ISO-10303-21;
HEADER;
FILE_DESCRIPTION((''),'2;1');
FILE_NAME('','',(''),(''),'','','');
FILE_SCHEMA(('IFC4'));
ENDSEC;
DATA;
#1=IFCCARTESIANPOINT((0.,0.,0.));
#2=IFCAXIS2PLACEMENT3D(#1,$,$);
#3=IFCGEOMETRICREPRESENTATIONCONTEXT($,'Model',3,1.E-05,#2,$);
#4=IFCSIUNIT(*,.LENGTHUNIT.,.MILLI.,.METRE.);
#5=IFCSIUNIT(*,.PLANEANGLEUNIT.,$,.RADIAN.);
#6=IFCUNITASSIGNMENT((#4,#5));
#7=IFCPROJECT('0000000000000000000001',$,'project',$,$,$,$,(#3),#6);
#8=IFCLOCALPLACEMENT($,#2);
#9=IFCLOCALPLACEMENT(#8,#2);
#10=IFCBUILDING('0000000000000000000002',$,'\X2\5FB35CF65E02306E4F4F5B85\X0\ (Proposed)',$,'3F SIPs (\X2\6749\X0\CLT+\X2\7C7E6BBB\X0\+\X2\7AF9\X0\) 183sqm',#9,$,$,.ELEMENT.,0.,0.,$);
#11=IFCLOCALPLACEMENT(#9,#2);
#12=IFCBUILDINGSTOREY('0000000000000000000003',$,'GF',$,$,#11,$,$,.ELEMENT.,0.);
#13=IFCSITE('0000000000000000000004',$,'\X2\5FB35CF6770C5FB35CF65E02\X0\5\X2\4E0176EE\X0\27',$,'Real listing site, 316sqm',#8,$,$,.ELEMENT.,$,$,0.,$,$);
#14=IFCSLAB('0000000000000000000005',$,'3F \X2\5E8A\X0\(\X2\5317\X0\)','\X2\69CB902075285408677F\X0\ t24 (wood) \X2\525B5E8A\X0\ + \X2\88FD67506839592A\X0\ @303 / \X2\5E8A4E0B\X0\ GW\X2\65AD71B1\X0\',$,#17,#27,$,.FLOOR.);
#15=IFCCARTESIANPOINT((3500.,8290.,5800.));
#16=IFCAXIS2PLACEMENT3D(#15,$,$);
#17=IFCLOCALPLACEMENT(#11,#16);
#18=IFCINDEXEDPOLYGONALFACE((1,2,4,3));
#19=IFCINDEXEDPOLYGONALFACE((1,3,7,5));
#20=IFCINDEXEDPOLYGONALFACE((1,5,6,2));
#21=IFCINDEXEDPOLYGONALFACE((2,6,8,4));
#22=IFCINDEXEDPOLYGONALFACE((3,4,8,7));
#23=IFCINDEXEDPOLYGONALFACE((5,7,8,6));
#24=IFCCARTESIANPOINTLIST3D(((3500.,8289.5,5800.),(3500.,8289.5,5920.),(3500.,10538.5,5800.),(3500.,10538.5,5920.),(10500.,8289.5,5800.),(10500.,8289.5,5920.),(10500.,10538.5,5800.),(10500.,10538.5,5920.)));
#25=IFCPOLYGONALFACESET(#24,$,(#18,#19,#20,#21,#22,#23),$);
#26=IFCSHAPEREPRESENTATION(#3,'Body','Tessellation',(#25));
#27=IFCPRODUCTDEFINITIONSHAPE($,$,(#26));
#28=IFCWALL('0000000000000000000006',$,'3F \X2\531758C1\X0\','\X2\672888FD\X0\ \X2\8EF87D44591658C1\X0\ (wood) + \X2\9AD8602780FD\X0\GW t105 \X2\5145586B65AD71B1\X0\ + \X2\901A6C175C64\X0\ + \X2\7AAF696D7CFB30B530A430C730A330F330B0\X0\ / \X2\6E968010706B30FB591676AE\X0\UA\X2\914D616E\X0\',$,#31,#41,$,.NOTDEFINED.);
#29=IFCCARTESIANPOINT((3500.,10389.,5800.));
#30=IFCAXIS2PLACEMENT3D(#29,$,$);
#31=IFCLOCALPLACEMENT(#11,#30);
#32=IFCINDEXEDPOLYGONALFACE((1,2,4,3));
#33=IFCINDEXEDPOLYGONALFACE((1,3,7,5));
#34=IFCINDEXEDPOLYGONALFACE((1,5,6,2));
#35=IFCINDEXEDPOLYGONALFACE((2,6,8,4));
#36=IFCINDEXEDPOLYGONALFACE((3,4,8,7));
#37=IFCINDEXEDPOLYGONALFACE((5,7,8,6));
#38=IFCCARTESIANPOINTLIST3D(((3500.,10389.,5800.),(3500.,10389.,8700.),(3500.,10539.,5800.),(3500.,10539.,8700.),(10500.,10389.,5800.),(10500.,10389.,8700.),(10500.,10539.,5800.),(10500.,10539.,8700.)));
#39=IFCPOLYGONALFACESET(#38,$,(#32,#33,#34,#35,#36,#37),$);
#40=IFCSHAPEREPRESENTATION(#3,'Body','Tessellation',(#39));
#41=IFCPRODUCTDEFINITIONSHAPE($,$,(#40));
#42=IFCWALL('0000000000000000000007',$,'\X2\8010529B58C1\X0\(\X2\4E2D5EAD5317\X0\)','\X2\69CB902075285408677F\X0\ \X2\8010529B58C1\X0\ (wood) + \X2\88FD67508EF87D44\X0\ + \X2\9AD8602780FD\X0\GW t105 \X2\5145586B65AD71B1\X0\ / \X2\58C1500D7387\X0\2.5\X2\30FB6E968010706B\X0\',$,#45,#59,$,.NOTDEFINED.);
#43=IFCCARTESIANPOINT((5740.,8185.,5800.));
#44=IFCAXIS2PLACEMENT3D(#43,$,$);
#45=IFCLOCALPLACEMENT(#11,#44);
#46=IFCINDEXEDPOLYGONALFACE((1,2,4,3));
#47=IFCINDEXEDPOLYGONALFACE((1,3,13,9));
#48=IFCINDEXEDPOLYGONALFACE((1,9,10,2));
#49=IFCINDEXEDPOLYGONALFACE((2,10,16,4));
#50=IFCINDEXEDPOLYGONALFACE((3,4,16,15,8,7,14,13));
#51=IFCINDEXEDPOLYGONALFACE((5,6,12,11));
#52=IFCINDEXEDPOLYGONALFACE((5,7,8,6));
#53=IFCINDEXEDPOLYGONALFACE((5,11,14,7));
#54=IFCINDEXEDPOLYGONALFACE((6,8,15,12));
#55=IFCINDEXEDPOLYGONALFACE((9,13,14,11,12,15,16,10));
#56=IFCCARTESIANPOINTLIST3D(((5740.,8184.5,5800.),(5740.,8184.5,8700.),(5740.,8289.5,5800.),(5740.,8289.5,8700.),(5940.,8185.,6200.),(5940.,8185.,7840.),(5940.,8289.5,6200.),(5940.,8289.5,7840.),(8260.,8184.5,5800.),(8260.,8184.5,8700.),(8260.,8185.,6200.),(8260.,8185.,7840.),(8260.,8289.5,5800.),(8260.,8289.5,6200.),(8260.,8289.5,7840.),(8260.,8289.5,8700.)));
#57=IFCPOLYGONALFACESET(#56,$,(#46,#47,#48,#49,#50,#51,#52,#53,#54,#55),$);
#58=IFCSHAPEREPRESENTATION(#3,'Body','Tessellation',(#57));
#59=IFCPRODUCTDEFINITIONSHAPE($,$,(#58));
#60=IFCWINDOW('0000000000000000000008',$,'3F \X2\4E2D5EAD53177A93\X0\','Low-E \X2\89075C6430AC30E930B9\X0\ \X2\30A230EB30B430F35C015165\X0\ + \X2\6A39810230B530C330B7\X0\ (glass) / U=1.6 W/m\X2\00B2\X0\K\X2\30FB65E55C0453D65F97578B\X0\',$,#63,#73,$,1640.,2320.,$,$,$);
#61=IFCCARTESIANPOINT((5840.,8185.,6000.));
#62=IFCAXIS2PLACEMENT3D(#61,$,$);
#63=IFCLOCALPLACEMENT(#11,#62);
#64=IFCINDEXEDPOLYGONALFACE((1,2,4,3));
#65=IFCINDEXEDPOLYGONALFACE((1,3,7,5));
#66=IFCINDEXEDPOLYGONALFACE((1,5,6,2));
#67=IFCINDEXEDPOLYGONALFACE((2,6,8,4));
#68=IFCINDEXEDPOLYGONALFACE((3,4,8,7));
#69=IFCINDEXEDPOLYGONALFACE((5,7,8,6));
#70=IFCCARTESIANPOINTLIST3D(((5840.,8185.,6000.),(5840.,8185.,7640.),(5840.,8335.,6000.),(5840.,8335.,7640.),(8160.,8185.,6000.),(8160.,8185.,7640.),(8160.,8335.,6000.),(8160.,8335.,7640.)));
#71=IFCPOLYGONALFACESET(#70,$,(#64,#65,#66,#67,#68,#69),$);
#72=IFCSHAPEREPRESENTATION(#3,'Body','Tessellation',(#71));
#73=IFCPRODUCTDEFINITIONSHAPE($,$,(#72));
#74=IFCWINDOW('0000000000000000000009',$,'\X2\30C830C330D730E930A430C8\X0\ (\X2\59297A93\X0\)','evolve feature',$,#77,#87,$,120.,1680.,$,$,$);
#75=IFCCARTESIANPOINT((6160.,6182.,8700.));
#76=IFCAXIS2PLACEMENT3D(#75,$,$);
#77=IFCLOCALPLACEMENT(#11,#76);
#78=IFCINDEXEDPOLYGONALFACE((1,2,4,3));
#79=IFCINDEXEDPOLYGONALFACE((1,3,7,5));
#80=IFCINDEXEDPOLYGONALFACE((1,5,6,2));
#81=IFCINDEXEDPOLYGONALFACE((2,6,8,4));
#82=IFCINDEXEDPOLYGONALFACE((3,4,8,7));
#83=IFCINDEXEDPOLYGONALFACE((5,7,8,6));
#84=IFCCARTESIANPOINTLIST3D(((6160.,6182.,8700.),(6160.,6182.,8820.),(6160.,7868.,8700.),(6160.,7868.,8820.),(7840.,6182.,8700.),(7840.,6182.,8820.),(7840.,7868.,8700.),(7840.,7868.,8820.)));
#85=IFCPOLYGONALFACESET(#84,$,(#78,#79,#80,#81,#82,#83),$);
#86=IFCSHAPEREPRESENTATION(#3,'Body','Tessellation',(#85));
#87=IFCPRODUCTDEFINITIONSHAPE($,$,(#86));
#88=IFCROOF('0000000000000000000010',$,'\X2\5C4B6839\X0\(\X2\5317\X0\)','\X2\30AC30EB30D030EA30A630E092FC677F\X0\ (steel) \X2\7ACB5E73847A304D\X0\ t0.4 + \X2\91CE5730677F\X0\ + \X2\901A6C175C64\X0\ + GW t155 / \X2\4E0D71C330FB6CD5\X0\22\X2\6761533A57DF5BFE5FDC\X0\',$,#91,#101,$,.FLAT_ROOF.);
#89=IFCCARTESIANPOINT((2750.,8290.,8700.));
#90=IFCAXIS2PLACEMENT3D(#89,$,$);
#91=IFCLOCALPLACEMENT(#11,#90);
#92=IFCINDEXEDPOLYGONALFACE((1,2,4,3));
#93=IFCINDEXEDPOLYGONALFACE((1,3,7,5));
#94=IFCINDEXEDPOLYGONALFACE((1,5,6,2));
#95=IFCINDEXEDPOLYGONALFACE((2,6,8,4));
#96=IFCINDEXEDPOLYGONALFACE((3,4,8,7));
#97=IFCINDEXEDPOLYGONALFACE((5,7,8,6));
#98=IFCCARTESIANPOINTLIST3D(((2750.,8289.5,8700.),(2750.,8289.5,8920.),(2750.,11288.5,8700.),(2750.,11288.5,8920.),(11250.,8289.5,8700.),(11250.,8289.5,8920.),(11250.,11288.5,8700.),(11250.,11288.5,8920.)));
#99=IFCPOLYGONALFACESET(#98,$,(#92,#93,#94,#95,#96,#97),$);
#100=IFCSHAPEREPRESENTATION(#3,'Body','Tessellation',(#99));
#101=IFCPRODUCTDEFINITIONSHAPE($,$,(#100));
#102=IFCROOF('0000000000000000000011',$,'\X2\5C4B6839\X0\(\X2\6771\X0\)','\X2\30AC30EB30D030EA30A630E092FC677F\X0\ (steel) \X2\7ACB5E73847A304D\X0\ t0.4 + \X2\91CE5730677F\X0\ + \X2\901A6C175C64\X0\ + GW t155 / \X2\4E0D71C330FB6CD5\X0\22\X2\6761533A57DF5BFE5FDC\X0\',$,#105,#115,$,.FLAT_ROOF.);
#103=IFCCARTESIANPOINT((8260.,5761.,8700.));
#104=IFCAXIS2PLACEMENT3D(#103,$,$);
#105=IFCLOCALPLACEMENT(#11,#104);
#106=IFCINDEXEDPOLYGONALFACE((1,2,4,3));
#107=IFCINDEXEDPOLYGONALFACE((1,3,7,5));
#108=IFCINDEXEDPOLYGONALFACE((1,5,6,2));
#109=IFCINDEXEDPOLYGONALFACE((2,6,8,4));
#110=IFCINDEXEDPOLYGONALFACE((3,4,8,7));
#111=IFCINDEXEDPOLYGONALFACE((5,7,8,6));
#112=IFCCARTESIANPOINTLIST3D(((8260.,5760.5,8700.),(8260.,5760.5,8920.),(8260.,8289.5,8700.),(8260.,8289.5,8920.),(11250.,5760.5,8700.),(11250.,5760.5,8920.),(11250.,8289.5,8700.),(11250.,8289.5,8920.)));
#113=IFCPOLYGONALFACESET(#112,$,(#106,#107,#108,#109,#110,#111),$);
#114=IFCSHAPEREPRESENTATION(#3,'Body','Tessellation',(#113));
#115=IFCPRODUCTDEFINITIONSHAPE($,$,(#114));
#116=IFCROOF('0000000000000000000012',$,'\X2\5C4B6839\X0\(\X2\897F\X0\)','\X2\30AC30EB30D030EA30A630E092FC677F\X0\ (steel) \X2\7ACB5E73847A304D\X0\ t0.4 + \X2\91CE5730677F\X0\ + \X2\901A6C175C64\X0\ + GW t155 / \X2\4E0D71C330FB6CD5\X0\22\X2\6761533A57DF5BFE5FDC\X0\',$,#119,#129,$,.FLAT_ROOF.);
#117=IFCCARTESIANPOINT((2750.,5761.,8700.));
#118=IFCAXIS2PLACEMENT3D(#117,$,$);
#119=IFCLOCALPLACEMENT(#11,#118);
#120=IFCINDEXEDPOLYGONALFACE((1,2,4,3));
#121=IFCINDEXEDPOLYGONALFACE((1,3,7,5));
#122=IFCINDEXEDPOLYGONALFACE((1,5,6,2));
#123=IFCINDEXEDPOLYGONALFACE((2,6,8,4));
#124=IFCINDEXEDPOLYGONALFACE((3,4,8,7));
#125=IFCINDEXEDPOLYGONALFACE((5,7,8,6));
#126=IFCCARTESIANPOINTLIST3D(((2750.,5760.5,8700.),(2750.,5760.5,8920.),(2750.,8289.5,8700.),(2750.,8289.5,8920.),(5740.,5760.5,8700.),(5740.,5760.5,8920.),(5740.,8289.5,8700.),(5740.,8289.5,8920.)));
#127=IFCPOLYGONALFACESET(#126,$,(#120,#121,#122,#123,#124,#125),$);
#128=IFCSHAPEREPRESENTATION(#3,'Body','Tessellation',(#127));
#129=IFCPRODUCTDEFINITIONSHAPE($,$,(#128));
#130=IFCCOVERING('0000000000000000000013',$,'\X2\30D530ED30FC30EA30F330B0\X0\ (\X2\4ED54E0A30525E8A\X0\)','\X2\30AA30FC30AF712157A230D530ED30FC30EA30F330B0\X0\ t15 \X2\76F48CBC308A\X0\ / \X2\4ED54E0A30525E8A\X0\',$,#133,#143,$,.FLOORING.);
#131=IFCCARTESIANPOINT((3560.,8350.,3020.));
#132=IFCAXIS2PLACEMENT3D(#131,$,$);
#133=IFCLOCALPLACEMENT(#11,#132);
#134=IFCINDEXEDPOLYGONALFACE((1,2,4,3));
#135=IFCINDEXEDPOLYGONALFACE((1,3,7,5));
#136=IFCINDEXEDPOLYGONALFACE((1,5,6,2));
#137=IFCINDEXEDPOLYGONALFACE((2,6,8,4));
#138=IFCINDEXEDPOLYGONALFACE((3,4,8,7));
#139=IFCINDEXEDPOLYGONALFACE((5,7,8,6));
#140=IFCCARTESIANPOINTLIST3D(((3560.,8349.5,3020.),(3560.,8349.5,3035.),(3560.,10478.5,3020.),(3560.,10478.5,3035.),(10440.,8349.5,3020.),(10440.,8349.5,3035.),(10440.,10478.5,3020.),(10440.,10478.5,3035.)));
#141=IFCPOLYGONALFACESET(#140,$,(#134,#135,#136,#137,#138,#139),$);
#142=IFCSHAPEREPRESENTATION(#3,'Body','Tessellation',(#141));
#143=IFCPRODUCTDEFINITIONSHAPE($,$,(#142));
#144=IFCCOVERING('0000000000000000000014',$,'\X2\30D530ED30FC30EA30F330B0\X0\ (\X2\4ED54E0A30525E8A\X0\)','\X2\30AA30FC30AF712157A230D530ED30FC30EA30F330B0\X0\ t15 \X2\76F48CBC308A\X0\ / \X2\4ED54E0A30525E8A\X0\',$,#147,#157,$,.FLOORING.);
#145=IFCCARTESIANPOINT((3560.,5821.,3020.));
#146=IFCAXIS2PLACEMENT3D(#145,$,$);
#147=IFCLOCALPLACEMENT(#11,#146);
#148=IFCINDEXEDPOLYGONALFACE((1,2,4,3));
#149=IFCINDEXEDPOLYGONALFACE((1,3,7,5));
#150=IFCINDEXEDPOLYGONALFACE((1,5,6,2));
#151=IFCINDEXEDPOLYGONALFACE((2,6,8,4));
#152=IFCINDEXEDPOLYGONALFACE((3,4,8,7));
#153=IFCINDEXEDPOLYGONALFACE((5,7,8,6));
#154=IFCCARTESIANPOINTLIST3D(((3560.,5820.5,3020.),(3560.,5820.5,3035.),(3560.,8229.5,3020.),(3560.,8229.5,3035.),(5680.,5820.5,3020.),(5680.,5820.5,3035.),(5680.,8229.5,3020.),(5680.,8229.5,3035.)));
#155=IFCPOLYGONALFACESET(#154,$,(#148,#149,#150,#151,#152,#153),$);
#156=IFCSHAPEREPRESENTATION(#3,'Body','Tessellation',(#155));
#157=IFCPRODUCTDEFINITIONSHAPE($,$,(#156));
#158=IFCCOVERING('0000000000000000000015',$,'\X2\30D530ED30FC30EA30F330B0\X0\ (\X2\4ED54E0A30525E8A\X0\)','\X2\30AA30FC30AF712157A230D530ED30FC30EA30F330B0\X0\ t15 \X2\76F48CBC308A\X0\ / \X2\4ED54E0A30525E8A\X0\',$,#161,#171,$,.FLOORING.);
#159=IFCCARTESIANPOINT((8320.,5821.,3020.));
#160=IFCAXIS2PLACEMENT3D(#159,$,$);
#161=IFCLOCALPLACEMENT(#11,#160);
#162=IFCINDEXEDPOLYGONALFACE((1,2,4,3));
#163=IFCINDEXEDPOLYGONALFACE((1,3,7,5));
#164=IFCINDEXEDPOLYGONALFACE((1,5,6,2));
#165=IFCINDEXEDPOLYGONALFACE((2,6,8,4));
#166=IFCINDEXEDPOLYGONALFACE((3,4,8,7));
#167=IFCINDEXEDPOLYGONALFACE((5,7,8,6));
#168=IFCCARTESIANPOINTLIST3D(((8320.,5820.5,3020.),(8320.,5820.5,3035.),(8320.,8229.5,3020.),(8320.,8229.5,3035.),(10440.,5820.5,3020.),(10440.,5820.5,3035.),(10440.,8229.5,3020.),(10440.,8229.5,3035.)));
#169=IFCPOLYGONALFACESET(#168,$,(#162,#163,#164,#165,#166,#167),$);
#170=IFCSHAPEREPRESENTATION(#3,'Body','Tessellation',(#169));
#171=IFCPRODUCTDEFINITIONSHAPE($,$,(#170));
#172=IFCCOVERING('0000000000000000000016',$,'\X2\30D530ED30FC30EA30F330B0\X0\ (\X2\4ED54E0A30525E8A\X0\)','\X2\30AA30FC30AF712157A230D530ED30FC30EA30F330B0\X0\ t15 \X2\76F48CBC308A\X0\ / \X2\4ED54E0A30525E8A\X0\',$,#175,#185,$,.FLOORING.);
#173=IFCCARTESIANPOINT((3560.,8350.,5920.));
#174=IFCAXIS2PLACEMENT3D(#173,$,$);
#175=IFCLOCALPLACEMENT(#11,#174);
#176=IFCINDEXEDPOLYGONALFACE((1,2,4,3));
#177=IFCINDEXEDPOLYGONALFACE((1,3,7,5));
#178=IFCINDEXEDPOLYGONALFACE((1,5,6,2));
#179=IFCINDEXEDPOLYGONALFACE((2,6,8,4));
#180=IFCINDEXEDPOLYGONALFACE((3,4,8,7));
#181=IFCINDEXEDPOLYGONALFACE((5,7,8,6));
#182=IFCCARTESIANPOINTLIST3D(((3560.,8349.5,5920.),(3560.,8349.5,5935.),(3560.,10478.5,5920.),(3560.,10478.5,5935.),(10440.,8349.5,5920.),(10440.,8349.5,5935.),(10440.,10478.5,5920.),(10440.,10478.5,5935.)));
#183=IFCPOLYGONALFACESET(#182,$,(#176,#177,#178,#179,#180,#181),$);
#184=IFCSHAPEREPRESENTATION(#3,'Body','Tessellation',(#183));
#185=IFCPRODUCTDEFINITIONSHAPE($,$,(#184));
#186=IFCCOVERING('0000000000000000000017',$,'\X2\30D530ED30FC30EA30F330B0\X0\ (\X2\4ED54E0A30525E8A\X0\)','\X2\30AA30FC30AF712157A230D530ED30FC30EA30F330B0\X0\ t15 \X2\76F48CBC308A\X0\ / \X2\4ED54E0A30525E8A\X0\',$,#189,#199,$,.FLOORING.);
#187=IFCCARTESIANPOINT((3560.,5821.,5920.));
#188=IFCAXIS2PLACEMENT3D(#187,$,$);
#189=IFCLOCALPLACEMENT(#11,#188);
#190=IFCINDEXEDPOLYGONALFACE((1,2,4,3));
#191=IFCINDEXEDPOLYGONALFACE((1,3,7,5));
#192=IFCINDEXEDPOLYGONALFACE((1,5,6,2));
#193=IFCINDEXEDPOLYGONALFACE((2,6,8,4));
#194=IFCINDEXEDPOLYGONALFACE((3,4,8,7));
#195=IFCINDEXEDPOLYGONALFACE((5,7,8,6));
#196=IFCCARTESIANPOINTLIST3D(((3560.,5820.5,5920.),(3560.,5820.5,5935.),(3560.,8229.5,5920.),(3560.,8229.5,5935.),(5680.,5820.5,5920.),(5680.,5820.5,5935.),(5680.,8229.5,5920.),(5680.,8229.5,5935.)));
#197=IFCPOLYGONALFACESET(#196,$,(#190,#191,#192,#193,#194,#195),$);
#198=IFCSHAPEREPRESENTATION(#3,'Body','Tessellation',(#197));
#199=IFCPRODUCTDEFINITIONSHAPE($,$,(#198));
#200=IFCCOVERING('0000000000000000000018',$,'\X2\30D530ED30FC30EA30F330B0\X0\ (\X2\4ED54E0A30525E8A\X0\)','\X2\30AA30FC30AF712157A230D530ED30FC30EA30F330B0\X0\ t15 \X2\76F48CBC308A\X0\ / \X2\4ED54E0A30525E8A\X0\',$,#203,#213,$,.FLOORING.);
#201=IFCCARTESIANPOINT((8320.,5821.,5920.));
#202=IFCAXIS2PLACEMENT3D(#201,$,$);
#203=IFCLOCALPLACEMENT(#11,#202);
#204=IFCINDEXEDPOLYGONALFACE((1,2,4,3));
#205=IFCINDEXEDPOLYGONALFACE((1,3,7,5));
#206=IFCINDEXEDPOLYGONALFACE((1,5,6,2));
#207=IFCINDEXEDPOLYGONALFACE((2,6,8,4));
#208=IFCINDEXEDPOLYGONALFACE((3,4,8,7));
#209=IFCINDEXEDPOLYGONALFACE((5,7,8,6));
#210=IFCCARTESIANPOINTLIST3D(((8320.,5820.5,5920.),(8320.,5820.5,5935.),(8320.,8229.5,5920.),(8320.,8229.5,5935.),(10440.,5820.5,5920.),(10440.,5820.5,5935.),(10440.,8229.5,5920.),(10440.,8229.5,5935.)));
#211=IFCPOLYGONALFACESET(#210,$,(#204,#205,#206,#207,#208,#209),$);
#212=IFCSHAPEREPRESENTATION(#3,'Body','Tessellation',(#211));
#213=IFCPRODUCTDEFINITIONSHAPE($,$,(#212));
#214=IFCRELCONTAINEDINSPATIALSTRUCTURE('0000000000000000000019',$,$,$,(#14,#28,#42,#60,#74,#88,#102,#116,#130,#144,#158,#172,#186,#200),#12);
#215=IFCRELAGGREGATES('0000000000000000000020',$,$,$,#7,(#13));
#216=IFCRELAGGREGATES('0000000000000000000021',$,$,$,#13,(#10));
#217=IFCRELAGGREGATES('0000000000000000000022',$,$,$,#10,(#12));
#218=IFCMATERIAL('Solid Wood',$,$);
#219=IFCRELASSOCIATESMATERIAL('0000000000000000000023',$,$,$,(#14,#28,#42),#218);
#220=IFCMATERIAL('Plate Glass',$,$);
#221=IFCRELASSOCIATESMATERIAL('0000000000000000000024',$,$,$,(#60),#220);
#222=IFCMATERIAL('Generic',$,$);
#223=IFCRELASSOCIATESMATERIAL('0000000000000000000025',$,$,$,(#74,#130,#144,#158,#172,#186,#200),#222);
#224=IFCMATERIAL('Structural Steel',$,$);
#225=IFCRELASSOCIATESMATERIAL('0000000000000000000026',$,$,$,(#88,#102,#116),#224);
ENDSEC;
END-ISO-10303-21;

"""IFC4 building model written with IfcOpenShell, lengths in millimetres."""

from ifc_helpers import new_model, si_unit, frame, frame_2d, origin, place, context, project, spatial, rectangle, extrude, material, element, fill, save


model = new_model("IFC4")

# Units and contexts
model_context = context("Model", 3, precision=1e-05, world=origin())
ifc_project = project(units=[si_unit("LENGTHUNIT", "METRE", prefix="MILLI"), si_unit("PLANEANGLEUNIT", "RADIAN")], contexts=[model_context])

# Site, building, storey
site_placement = place(None, origin())
site = spatial("IfcSite", under=ifc_project, at=site_placement, Name="徳島県徳島市5丁目27", ObjectType="Real listing site, 316sqm", CompositionType="ELEMENT", RefElevation=0.0)
building_placement = place(site_placement, origin())
building = spatial("IfcBuilding", under=site, at=building_placement, Name="徳島市の住宅 (Proposed)", ObjectType="3F SIPs (杉CLT+籾殻+竹) 183sqm", CompositionType="ELEMENT", ElevationOfRefHeight=0.0, ElevationOfTerrain=0.0)
storey_placement = place(building_placement, origin())
storey = spatial("IfcBuildingStorey", under=building, at=storey_placement, Name="GF", CompositionType="ELEMENT", Elevation=0.0)

# Slab
ifc_material_1 = material(Name="Solid Wood")
slab_placement = place(storey_placement, frame((3500.0, 8290.0, 5800.0)))
element("IfcSlab", 1, at=slab_placement, inside=storey, material=ifc_material_1, Name="3F 床(北)", Description="構造用合板 t24 (wood) 剛床 + 製材根太 @303 / 床下 GW断熱", PredefinedType="FLOOR", context=model_context, shape_type="SweptSolid", body=[
    extrude(rectangle(XDim=7000.0, YDim=2249.0, at=frame_2d((3500.0, 1124.0))), frame((3500.0, 8290.0, 5800.0)), (0.0, 0.0, 1.0), 120.0),
])

# Wall
wall_1_placement = place(storey_placement, frame((3500.0, 10389.0, 5800.0)))
element("IfcWall", 2, at=wall_1_placement, inside=storey, material=ifc_material_1, Name="3F 北壁", Description="木製 軸組外壁 (wood) + 高性能GW t105 充填断熱 + 通気層 + 窯業系サイディング / 準耐火・外皮UA配慮", PredefinedType="NOTDEFINED", context=model_context, shape_type="SweptSolid", body=[
    extrude(rectangle(XDim=7000.0, YDim=150.0, at=frame_2d((3500.0, 75.0))), frame((3500.0, 10389.0, 5800.0)), (0.0, 0.0, 1.0), 2900.0),
])

# Wall, opening, window
wall_2_placement = place(storey_placement, frame((5740.0, 8185.0, 5800.0)))
wall_2 = element("IfcWall", 3, at=wall_2_placement, inside=storey, material=ifc_material_1, Name="耐力壁(中庭北)", Description="構造用合板 耐力壁 (wood) + 製材軸組 + 高性能GW t105 充填断熱 / 壁倍率2.5・準耐火", PredefinedType="NOTDEFINED", context=model_context, shape_type="SweptSolid", body=[
    extrude(rectangle(XDim=2520.0, YDim=105.0, at=frame_2d((1260.0, 52.0))), frame((5740.0, 8185.0, 5800.0)), (0.0, 0.0, 1.0), 2900.0),
])
opening_placement = place(storey_placement, frame((5840.0, 8185.0, 6000.0)))
opening = element("IfcOpeningElement", 4, at=opening_placement, cuts=wall_2, PredefinedType="NOTDEFINED", context=model_context, shape_type="SweptSolid", body=[
    extrude(rectangle(XDim=2320.0, YDim=150.0, at=frame_2d((1160.0, 75.0))), frame((5840.0, 8185.0, 6000.0)), (0.0, 0.0, 1.0), 1640.0),
])
ifc_material_2 = material(Name="Plate Glass")
window_1_placement = place(storey_placement, frame((5840.0, 8185.0, 6000.0)))
window_1 = element("IfcWindow", 5, at=window_1_placement, inside=storey, material=ifc_material_2, Name="3F 中庭北窓", Description="Low-E 複層ガラス アルゴン封入 + 樹脂サッシ (glass) / U=1.6 W/m²K・日射取得型", OverallHeight=1640.0, OverallWidth=2320.0, context=model_context, shape_type="SweptSolid", body=[
    extrude(rectangle(XDim=2320.0, YDim=150.0, at=frame_2d((1160.0, 75.0))), frame((5840.0, 8185.0, 6000.0)), (0.0, 0.0, 1.0), 1640.0),
])
fill(opening, window_1)

# Window
ifc_material_3 = material(Name="Generic")
window_2_placement = place(storey_placement, frame((6160.0, 6182.0, 8700.0)))
element("IfcWindow", 6, at=window_2_placement, inside=storey, material=ifc_material_3, Name="トップライト (天窓)", Description="evolve feature", OverallHeight=120.0, OverallWidth=1680.0, context=model_context, shape_type="SweptSolid", body=[
    extrude(rectangle(XDim=1680.0, YDim=1686.0, at=frame_2d((840.0, 843.0))), frame((6160.0, 6182.0, 8700.0)), (0.0, 0.0, 1.0), 120.0),
])

# Roofs
ifc_material_4 = material(Name="Structural Steel")
roof_1_placement = place(storey_placement, frame((2750.0, 8290.0, 8700.0)))
element("IfcRoof", 7, at=roof_1_placement, inside=storey, material=ifc_material_4, Name="屋根(北)", Description="ガルバリウム鋼板 (steel) 立平葺き t0.4 + 野地板 + 通気層 + GW t155 / 不燃・法22条区域対応", PredefinedType="FLAT_ROOF", context=model_context, shape_type="SweptSolid", body=[
    extrude(rectangle(XDim=8500.0, YDim=2999.0, at=frame_2d((4250.0, 1499.0))), frame((2750.0, 8290.0, 8700.0)), (0.0, 0.0, 1.0), 220.0),
])
roof_2_placement = place(storey_placement, frame((8260.0, 5761.0, 8700.0)))
element("IfcRoof", 8, at=roof_2_placement, inside=storey, material=ifc_material_4, Name="屋根(東)", Description="ガルバリウム鋼板 (steel) 立平葺き t0.4 + 野地板 + 通気層 + GW t155 / 不燃・法22条区域対応", PredefinedType="FLAT_ROOF", context=model_context, shape_type="SweptSolid", body=[
    extrude(rectangle(XDim=2990.0, YDim=2529.0, at=frame_2d((1495.0, 1264.0))), frame((8260.0, 5761.0, 8700.0)), (0.0, 0.0, 1.0), 220.0),
])
roof_3_placement = place(storey_placement, frame((2750.0, 5761.0, 8700.0)))
element("IfcRoof", 9, at=roof_3_placement, inside=storey, material=ifc_material_4, Name="屋根(西)", Description="ガルバリウム鋼板 (steel) 立平葺き t0.4 + 野地板 + 通気層 + GW t155 / 不燃・法22条区域対応", PredefinedType="FLAT_ROOF", context=model_context, shape_type="SweptSolid", body=[
    extrude(rectangle(XDim=2990.0, YDim=2529.0, at=frame_2d((1495.0, 1264.0))), frame((2750.0, 5761.0, 8700.0)), (0.0, 0.0, 1.0), 220.0),
])

# Coverings
covering_1_placement = place(storey_placement, frame((3560.0, 8350.0, 3020.0)))
element("IfcCovering", 10, at=covering_1_placement, inside=storey, material=ifc_material_3, Name="フローリング (仕上げ床)", Description="オーク無垢フローリング t15 直貼り / 仕上げ床", PredefinedType="FLOORING", context=model_context, shape_type="SweptSolid", body=[
    extrude(rectangle(XDim=6880.0, YDim=2129.0, at=frame_2d((3440.0, 1064.0))), frame((3560.0, 8350.0, 3020.0)), (0.0, 0.0, 1.0), 15.0),
])
covering_2_placement = place(storey_placement, frame((3560.0, 5821.0, 3020.0)))
element("IfcCovering", 11, at=covering_2_placement, inside=storey, material=ifc_material_3, Name="フローリング (仕上げ床)", Description="オーク無垢フローリング t15 直貼り / 仕上げ床", PredefinedType="FLOORING", context=model_context, shape_type="SweptSolid", body=[
    extrude(rectangle(XDim=2120.0, YDim=2409.0, at=frame_2d((1060.0, 1204.0))), frame((3560.0, 5821.0, 3020.0)), (0.0, 0.0, 1.0), 15.0),
])
covering_3_placement = place(storey_placement, frame((8320.0, 5821.0, 3020.0)))
element("IfcCovering", 12, at=covering_3_placement, inside=storey, material=ifc_material_3, Name="フローリング (仕上げ床)", Description="オーク無垢フローリング t15 直貼り / 仕上げ床", PredefinedType="FLOORING", context=model_context, shape_type="SweptSolid", body=[
    extrude(rectangle(XDim=2120.0, YDim=2409.0, at=frame_2d((1060.0, 1204.0))), frame((8320.0, 5821.0, 3020.0)), (0.0, 0.0, 1.0), 15.0),
])
covering_4_placement = place(storey_placement, frame((3560.0, 8350.0, 5920.0)))
element("IfcCovering", 13, at=covering_4_placement, inside=storey, material=ifc_material_3, Name="フローリング (仕上げ床)", Description="オーク無垢フローリング t15 直貼り / 仕上げ床", PredefinedType="FLOORING", context=model_context, shape_type="SweptSolid", body=[
    extrude(rectangle(XDim=6880.0, YDim=2129.0, at=frame_2d((3440.0, 1064.0))), frame((3560.0, 8350.0, 5920.0)), (0.0, 0.0, 1.0), 15.0),
])
covering_5_placement = place(storey_placement, frame((3560.0, 5821.0, 5920.0)))
element("IfcCovering", 14, at=covering_5_placement, inside=storey, material=ifc_material_3, Name="フローリング (仕上げ床)", Description="オーク無垢フローリング t15 直貼り / 仕上げ床", PredefinedType="FLOORING", context=model_context, shape_type="SweptSolid", body=[
    extrude(rectangle(XDim=2120.0, YDim=2409.0, at=frame_2d((1060.0, 1204.0))), frame((3560.0, 5821.0, 5920.0)), (0.0, 0.0, 1.0), 15.0),
])
covering_6_placement = place(storey_placement, frame((8320.0, 5821.0, 5920.0)))
element("IfcCovering", 15, at=covering_6_placement, inside=storey, material=ifc_material_3, Name="フローリング (仕上げ床)", Description="オーク無垢フローリング t15 直貼り / 仕上げ床", PredefinedType="FLOORING", context=model_context, shape_type="SweptSolid", body=[
    extrude(rectangle(XDim=2120.0, YDim=2409.0, at=frame_2d((1060.0, 1204.0))), frame((8320.0, 5821.0, 5920.0)), (0.0, 0.0, 1.0), 15.0),
])

save(model, "model.ifc")
